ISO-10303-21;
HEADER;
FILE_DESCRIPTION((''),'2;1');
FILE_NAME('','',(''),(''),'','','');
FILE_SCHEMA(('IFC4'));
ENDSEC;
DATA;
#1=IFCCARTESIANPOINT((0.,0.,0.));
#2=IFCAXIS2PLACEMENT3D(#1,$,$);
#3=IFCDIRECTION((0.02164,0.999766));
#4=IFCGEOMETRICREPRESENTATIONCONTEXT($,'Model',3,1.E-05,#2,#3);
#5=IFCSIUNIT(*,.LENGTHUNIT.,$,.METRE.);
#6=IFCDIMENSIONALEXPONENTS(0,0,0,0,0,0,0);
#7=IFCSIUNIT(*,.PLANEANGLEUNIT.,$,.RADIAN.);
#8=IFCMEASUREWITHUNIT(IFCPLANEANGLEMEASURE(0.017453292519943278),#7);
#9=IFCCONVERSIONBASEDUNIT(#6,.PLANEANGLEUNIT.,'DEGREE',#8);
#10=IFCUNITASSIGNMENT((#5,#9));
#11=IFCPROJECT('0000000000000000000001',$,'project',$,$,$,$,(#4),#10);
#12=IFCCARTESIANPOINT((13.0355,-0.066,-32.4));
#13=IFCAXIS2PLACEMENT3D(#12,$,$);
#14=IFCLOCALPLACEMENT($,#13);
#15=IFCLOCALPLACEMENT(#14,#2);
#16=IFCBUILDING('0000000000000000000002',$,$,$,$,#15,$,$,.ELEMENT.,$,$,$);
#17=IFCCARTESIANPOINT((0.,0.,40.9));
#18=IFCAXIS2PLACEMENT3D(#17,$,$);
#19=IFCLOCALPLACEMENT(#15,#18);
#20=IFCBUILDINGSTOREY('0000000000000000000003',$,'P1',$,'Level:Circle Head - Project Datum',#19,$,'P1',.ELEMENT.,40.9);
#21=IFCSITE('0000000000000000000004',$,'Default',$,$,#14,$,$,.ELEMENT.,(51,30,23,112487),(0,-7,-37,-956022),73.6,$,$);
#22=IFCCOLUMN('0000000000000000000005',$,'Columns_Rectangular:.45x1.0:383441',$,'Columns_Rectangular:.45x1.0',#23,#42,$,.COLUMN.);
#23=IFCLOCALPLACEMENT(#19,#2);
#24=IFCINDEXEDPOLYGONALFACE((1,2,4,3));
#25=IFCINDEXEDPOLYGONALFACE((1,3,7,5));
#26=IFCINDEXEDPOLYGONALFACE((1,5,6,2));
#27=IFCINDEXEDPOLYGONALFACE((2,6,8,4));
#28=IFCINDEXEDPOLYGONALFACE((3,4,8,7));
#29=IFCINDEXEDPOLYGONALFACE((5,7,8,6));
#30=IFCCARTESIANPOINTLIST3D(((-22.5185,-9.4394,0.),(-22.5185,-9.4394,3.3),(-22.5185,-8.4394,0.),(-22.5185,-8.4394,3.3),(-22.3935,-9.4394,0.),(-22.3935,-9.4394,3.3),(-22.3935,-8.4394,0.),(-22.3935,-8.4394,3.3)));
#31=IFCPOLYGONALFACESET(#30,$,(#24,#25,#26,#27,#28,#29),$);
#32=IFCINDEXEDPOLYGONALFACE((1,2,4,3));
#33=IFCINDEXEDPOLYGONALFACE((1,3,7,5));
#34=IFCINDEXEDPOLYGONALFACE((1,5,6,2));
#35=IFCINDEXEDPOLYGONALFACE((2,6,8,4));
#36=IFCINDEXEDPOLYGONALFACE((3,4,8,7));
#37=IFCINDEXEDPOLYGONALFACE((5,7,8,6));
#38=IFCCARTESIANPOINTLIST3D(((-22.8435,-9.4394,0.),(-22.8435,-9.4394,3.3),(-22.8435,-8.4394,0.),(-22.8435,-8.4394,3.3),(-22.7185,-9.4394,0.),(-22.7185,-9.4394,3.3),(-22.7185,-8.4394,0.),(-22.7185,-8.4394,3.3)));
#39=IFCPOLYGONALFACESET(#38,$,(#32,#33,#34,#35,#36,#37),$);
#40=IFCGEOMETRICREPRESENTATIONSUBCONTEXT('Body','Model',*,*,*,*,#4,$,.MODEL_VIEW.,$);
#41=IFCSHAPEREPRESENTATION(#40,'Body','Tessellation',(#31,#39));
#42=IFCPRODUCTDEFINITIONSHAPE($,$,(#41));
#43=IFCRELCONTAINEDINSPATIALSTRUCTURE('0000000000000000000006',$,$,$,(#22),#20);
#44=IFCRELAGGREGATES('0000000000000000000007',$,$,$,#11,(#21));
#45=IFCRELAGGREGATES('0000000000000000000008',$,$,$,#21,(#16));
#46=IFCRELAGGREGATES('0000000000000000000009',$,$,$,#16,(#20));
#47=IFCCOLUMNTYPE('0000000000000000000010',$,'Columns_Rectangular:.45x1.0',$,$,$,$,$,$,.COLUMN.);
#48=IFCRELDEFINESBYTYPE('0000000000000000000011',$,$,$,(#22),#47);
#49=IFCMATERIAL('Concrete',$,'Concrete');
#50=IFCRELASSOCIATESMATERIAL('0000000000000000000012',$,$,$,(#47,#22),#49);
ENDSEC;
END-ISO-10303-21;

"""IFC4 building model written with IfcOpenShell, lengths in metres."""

from ifc_helpers import new_model, entity, si_unit, converted_unit, direction, frame, origin, place, context, subcontext, project, spatial, indexed_curve, outline, extrude, source, transform, mapped, material, type_object, type_shapes, element, save


model = new_model("IFC4")

# Units and contexts
model_context = context("Model", 3, precision=1e-05, world=origin(), true_north=direction((0.02164, 0.999766)))
body_context = subcontext(model_context, "Body", "Model", "MODEL_VIEW")
ifc_project = project(units=[si_unit("LENGTHUNIT", "METRE"), converted_unit("PLANEANGLEUNIT", "DEGREE", entity("IfcPlaneAngleMeasure", 0.017453292519943278), si_unit("PLANEANGLEUNIT", "RADIAN"), dimensions=[0, 0, 0, 0, 0, 0, 0])], contexts=[model_context])

# Site, building, storey
site_placement = place(None, frame((13.0355, -0.066, -32.4)))
site = spatial("IfcSite", under=ifc_project, at=site_placement, Name="Default", CompositionType="ELEMENT", RefLatitude=(51, 30, 23, 112487), RefLongitude=(0, -7, -37, -956022), RefElevation=73.6)
building_placement = place(site_placement, origin())
building = spatial("IfcBuilding", under=site, at=building_placement, CompositionType="ELEMENT")
storey_placement = place(building_placement, frame((0.0, 0.0, 40.9)))
storey = spatial("IfcBuildingStorey", under=building, at=storey_placement, Name="P1", ObjectType="Level:Circle Head - Project Datum", LongName="P1", CompositionType="ELEMENT", Elevation=40.9)

# Column
ifc_material = material(Name="Concrete", Category="Concrete")
column_type_1 = type_object("IfcColumnType", Name="Columns_Rectangular:.45x1.0", PredefinedType="COLUMN", material=ifc_material)
shared_shape_1 = source(origin(), body_context, "Body", "SweptSolid", [
    extrude(outline(indexed_curve([(-0.0625, -0.5), (0.0625, -0.5), (0.0625, 0.5), (-0.0625, 0.5), (-0.0625, -0.5)], self_intersect=False)), frame((-22.456, -8.9394, 40.9), z_axis=(0.0, 0.0, 1.0), x_axis=(-1.0, 0.0, 0.0)), (0.0, 0.0, 1.0), 3.3),
    extrude(outline(indexed_curve([(-0.0625, -0.5), (0.0625, -0.5), (0.0625, 0.5), (-0.0625, 0.5), (-0.0625, -0.5)], self_intersect=False)), frame((-22.781, -8.9394, 40.9)), (0.0, 0.0, 1.0), 3.3),
])
type_shapes(column_type_1, [shared_shape_1])
column_1_placement = place(storey_placement, frame((0.0, 0.0, -40.9)))
element("IfcColumn", 1, at=column_1_placement, inside=storey, type_object=column_type_1, material=ifc_material, Name="Columns_Rectangular:.45x1.0:383441", ObjectType="Columns_Rectangular:.45x1.0", PredefinedType="COLUMN", context=body_context, shape_type="MappedRepresentation", body=[
    mapped(shared_shape_1, transform((0.0, 0.0, 0.0), scale=1.0)),
])

save(model, "model.ifc")
